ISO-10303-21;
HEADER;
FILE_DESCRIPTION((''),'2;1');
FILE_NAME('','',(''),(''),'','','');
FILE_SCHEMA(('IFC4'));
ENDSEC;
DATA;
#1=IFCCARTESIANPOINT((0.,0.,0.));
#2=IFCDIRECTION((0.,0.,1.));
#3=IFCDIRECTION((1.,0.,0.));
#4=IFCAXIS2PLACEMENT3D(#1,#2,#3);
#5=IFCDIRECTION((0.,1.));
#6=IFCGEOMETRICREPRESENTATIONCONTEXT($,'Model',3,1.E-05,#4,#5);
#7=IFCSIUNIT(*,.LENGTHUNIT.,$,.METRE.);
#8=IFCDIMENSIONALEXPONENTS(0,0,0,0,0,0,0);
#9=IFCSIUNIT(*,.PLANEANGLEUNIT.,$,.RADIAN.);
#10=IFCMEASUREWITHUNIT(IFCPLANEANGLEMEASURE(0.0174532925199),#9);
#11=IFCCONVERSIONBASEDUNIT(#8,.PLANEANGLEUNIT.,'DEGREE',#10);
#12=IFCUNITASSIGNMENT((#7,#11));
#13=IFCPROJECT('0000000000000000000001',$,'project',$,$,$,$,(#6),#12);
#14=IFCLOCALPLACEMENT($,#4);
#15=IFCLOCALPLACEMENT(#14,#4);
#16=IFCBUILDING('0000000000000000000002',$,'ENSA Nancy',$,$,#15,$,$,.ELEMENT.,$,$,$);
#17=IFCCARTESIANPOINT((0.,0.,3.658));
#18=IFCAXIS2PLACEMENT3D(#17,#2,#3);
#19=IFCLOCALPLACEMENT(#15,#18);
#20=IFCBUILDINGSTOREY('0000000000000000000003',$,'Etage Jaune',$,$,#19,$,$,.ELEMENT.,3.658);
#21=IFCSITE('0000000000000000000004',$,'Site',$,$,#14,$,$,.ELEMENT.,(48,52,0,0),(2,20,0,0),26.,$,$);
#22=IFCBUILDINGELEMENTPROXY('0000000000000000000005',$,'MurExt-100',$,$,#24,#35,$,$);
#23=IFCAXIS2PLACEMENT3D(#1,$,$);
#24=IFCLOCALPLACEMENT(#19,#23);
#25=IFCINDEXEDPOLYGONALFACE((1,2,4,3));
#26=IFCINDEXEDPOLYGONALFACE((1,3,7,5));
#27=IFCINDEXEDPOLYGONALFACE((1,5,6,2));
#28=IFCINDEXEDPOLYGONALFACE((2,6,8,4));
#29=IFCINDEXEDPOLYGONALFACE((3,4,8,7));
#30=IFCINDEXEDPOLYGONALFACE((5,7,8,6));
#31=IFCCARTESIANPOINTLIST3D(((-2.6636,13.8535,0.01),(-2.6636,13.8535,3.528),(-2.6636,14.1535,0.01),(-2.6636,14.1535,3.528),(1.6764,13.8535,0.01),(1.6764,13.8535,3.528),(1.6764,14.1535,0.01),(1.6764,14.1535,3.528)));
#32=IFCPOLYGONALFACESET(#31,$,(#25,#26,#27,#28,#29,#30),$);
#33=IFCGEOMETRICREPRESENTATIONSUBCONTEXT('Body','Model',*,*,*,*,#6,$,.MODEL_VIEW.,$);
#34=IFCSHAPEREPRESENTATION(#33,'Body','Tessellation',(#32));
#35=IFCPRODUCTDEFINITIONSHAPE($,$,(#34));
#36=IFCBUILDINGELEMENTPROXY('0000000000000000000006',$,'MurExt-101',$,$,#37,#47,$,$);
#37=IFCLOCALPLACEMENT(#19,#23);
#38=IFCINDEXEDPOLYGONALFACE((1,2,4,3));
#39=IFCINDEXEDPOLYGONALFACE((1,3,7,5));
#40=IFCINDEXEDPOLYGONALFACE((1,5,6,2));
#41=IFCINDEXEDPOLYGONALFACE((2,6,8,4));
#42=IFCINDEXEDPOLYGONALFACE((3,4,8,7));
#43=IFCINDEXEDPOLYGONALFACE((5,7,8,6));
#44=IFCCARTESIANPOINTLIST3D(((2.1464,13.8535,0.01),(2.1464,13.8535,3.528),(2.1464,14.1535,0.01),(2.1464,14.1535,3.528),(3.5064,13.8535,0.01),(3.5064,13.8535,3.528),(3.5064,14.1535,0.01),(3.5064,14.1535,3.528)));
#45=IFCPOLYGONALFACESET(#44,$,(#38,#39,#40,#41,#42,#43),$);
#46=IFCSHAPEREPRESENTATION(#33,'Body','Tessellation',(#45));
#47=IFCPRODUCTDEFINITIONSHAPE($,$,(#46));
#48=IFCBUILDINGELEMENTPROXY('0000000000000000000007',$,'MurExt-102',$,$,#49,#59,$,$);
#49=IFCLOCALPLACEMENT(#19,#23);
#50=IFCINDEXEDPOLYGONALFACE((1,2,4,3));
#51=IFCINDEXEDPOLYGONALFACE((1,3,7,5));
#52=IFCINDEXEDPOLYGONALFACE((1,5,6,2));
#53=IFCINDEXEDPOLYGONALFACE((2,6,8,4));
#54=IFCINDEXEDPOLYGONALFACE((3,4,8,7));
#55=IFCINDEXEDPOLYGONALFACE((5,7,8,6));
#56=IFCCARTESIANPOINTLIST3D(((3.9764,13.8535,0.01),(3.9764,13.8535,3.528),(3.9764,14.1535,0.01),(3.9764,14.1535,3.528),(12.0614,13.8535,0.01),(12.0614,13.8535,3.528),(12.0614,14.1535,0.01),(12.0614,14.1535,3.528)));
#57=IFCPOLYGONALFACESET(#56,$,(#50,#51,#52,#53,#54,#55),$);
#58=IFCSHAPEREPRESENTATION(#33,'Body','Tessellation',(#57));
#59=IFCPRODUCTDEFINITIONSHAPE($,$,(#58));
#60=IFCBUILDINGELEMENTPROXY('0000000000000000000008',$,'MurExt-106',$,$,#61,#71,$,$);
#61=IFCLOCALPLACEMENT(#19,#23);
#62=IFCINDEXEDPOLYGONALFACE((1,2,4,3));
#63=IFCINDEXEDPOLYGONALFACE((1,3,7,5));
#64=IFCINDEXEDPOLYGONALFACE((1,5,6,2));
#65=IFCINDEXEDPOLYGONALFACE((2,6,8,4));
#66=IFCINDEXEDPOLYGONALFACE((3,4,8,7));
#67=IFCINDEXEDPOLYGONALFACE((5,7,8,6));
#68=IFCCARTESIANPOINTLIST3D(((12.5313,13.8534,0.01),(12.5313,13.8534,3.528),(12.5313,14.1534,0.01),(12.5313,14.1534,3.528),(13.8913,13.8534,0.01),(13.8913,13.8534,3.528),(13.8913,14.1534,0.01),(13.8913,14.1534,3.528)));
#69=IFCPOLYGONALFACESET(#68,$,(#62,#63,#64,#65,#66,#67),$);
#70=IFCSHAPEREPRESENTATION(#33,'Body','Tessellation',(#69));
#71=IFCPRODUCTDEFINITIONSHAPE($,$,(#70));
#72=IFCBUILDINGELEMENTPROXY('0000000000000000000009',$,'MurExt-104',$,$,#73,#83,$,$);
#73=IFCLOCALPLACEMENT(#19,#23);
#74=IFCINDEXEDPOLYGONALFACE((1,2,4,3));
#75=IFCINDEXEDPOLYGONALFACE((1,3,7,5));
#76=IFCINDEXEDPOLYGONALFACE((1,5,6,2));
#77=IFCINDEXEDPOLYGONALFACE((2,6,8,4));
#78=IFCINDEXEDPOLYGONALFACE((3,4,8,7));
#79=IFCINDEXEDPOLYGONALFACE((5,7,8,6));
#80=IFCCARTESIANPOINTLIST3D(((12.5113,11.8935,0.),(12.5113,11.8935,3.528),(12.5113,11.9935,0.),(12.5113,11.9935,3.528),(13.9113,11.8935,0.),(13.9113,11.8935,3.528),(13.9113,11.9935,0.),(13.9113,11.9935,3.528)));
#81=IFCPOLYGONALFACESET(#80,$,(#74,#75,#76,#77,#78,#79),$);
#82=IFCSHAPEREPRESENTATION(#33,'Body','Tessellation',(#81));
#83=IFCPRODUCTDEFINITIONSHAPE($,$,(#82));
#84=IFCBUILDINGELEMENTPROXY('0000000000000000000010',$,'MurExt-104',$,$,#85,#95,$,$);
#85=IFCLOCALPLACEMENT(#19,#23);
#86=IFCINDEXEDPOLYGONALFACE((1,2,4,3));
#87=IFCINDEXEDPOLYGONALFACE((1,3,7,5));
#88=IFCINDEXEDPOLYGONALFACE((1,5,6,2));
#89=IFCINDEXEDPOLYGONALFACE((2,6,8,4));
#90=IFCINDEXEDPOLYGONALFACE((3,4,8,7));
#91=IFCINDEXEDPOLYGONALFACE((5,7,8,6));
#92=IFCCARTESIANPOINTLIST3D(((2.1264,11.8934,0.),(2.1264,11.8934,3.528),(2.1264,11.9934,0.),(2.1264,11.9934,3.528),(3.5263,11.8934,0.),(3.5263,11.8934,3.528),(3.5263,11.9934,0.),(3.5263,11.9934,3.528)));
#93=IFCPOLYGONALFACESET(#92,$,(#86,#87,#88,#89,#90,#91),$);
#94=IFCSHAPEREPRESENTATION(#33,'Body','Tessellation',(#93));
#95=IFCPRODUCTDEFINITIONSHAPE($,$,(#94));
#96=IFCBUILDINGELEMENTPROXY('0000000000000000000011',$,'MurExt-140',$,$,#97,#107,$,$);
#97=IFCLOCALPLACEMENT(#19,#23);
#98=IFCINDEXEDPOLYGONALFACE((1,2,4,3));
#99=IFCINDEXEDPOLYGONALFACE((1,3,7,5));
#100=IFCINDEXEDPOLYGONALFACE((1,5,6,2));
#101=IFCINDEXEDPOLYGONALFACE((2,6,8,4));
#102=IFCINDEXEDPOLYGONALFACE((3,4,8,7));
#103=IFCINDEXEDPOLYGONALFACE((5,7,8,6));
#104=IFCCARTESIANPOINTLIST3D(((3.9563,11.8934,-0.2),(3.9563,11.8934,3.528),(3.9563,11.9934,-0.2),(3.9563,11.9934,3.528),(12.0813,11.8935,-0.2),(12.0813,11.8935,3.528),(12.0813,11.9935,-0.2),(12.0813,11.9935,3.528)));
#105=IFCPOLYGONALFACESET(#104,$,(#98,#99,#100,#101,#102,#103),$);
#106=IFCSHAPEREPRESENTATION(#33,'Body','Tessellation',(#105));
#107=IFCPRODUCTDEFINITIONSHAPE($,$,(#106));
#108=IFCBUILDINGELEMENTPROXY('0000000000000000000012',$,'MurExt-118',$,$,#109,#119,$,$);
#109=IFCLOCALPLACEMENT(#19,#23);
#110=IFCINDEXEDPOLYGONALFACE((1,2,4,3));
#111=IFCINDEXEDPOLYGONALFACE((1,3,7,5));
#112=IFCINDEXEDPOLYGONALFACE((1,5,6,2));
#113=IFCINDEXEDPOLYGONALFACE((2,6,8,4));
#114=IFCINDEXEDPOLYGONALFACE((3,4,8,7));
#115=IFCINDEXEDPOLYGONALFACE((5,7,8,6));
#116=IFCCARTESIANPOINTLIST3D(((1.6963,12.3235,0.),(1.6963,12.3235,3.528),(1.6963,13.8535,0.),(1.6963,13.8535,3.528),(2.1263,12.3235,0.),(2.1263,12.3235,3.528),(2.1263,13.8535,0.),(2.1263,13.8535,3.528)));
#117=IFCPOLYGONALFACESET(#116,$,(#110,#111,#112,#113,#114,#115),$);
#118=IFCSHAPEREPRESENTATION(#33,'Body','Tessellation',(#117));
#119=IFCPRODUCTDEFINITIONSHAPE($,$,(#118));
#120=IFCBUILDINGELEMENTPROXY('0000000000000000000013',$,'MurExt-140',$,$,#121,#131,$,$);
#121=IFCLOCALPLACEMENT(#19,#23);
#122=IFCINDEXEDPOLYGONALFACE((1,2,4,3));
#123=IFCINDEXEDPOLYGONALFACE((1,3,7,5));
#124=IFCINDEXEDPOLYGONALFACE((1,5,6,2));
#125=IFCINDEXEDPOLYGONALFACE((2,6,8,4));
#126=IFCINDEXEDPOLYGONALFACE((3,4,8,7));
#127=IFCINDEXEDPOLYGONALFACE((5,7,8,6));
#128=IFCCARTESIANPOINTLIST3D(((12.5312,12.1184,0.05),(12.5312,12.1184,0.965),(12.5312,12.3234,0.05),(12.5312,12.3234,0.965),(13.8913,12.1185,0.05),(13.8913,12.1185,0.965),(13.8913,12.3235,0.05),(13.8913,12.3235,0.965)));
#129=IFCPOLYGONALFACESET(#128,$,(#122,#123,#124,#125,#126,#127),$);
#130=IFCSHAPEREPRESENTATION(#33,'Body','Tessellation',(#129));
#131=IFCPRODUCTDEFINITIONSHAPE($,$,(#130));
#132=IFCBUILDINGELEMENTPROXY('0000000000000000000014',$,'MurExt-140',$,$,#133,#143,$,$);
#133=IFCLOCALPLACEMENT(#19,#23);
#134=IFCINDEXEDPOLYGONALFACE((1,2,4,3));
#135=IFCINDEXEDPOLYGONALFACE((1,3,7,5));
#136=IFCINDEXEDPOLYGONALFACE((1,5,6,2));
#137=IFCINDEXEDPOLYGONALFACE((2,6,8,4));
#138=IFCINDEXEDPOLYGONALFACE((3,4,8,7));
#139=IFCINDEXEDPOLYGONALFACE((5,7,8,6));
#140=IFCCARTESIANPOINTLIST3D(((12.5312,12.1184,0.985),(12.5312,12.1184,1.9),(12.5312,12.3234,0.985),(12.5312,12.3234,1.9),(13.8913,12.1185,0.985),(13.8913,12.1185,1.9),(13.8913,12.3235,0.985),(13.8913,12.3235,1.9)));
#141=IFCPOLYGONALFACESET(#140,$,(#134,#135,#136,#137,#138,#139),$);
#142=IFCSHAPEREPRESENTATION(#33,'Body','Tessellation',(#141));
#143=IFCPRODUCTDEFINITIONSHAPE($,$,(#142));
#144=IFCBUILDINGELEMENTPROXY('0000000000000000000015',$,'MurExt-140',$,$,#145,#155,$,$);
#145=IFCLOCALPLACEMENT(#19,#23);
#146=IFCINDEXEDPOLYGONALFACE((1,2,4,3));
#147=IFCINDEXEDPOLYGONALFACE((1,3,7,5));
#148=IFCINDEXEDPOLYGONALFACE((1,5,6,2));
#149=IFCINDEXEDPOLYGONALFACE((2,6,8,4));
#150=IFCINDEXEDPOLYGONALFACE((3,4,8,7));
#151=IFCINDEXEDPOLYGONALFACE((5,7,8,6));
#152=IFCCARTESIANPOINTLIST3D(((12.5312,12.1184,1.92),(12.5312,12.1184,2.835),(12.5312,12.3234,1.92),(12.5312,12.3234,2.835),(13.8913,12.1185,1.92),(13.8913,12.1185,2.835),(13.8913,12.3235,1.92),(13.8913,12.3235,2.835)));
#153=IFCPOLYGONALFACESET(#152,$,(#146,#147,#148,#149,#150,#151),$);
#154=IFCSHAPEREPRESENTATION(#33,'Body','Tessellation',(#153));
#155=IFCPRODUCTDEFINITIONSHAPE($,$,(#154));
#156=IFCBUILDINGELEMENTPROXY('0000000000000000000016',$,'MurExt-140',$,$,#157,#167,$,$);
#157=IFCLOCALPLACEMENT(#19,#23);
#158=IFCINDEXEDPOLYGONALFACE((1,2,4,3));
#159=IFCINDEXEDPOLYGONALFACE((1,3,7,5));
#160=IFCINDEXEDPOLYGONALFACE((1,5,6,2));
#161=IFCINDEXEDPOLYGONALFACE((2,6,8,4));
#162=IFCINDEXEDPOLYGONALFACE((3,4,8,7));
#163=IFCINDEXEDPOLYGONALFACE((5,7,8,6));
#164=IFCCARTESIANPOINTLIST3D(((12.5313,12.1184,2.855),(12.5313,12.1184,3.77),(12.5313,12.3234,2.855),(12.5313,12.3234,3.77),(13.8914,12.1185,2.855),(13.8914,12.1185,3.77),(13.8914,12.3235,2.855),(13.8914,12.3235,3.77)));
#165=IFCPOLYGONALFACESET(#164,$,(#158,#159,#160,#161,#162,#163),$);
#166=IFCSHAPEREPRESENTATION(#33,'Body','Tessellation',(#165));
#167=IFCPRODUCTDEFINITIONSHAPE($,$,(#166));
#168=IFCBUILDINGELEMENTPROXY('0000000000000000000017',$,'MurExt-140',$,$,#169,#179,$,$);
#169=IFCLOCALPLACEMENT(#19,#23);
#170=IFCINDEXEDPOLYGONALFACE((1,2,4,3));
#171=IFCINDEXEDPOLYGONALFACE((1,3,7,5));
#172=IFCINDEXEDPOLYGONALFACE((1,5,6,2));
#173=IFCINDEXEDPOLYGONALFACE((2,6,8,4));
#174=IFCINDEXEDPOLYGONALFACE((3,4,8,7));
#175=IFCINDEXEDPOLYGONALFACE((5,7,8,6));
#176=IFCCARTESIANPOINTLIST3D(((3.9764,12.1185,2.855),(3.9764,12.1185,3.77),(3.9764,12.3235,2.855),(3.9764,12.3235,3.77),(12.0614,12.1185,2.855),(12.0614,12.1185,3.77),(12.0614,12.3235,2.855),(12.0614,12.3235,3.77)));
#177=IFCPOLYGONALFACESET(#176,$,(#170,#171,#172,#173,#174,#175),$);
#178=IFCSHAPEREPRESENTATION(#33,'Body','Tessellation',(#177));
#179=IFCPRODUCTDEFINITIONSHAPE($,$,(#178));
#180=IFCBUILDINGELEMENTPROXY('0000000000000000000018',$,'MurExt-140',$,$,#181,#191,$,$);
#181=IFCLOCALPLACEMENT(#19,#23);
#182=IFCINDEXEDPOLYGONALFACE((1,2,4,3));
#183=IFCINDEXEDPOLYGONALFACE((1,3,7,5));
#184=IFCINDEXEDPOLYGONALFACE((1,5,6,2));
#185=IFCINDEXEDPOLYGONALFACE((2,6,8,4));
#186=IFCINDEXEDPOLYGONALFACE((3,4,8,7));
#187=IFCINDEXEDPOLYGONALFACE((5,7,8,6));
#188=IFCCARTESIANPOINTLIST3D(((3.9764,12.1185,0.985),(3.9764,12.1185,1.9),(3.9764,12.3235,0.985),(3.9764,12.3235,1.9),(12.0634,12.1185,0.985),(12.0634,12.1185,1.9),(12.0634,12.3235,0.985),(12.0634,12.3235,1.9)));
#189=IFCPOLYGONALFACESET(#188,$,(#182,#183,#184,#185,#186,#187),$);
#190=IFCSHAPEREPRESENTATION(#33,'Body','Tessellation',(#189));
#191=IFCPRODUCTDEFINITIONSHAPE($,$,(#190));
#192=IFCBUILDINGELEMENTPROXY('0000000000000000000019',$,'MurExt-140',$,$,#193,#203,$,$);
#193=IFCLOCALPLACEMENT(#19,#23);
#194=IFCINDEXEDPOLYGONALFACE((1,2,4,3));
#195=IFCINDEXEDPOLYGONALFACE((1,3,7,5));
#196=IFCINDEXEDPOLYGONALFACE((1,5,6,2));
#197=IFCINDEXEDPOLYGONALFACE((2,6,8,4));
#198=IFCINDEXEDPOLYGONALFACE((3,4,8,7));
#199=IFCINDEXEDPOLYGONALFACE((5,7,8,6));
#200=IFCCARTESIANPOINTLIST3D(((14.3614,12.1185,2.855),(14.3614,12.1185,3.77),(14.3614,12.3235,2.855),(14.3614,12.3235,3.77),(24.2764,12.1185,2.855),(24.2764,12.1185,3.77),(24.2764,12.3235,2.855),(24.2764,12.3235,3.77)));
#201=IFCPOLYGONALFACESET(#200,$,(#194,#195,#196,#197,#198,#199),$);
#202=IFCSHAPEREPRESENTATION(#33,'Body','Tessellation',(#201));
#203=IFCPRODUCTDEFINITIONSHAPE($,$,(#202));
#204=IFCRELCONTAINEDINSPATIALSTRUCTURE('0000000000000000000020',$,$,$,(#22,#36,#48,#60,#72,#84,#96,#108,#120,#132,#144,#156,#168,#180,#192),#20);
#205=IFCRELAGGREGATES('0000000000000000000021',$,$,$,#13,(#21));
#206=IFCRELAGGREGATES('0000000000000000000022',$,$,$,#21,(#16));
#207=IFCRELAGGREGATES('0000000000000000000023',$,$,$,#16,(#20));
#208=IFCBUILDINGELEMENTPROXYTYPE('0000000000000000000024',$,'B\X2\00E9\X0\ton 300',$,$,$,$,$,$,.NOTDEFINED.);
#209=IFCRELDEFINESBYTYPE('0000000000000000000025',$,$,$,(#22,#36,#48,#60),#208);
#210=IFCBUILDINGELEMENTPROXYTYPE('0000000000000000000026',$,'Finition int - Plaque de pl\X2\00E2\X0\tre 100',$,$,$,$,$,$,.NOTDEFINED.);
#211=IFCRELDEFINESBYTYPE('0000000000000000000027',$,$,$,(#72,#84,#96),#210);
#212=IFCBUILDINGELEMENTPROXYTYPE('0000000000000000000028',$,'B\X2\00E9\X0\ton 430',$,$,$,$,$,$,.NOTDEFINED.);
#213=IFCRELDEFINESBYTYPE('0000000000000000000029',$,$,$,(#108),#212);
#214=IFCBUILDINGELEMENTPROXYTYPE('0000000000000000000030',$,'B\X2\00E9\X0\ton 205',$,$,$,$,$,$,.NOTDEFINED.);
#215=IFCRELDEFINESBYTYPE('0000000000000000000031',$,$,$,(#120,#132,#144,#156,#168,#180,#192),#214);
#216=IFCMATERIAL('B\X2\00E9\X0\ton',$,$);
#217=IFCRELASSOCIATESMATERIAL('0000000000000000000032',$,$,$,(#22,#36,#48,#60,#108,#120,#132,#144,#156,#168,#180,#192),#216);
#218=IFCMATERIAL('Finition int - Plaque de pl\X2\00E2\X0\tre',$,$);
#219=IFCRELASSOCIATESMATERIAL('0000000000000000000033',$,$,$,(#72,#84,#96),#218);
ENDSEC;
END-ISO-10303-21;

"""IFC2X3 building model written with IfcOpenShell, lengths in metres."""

from ifc_helpers import new_model, entity, si_unit, converted_unit, direction, frame, origin_with_axes, place, context, subcontext, project, spatial, polyline, outline, extrude, material, type_object, element, save


model = new_model("IFC2X3")

# Units and contexts
model_context = context("Model", 3, precision=1e-05, world=origin_with_axes(), true_north=direction((0.0, 1.0)))
body_context = subcontext(model_context, "Body", "Model", "MODEL_VIEW")
ifc_project = project(units=[si_unit("LENGTHUNIT", "METRE"), converted_unit("PLANEANGLEUNIT", "DEGREE", entity("IfcPlaneAngleMeasure", 0.0174532925199), si_unit("PLANEANGLEUNIT", "RADIAN"), dimensions=[0, 0, 0, 0, 0, 0, 0])], contexts=[model_context])

# Site, building, storey
site_placement = place(None, origin_with_axes())
site = spatial("IfcSite", under=ifc_project, at=site_placement, Name="Site", CompositionType="ELEMENT", RefLatitude=(48, 52, 0, 0), RefLongitude=(2, 20, 0, 0), RefElevation=26.0)
building_placement = place(site_placement, origin_with_axes())
building = spatial("IfcBuilding", under=site, at=building_placement, Name="ENSA Nancy", CompositionType="ELEMENT")
storey_placement = place(building_placement, frame((0.0, 0.0, 3.658), z_axis=(0.0, 0.0, 1.0), x_axis=(1.0, 0.0, 0.0)))
storey = spatial("IfcBuildingStorey", under=building, at=storey_placement, Name="Etage Jaune", CompositionType="ELEMENT", Elevation=3.658)

# Building element proxies
ifc_material_1 = material(Name="Béton")
building_element_proxy_type_1 = type_object("IfcBuildingElementProxyType", Name="Béton 300", PredefinedType="NOTDEFINED")
proxy_1_placement = place(storey_placement, frame((-2.6636, 13.8535, 0.01), z_axis=(0.0, 0.0, 1.0), x_axis=(1.0, 0.0, 0.0)))
element("IfcBuildingElementProxy", 1, at=proxy_1_placement, inside=storey, type_object=building_element_proxy_type_1, material=ifc_material_1, Name="MurExt-100", context=body_context, shape_type="SweptSolid", body=[
    extrude(outline(polyline([(0.0, 0.0), (4.34, 0.0), (4.34, 0.3), (0.0, 0.3), (0.0, 0.0)])), origin_with_axes(), (0.0, 0.0, 1.0), 3.518),
])
proxy_2_placement = place(storey_placement, frame((2.1464, 13.8535, 0.01), z_axis=(0.0, 0.0, 1.0), x_axis=(1.0, 0.0, 0.0)))
element("IfcBuildingElementProxy", 2, at=proxy_2_placement, inside=storey, type_object=building_element_proxy_type_1, material=ifc_material_1, Name="MurExt-101", context=body_context, shape_type="SweptSolid", body=[
    extrude(outline(polyline([(0.0, 0.0), (1.36, 0.0), (1.36, 0.3), (0.0, 0.3), (0.0, 0.0)])), origin_with_axes(), (0.0, 0.0, 1.0), 3.518),
])
proxy_3_placement = place(storey_placement, frame((3.9764, 13.8535, 0.01), z_axis=(0.0, 0.0, 1.0), x_axis=(1.0, 0.000001, 0.0)))
element("IfcBuildingElementProxy", 3, at=proxy_3_placement, inside=storey, type_object=building_element_proxy_type_1, material=ifc_material_1, Name="MurExt-102", context=body_context, shape_type="SweptSolid", body=[
    extrude(outline(polyline([(0.0, 0.0), (8.085, 0.0), (8.085, 0.3), (0.0, 0.3), (0.0, 0.0)])), origin_with_axes(), (0.0, 0.0, 1.0), 3.518),
])
proxy_4_placement = place(storey_placement, frame((12.5313, 13.8534, 0.01), z_axis=(0.0, 0.0, 1.0), x_axis=(1.0, 0.0, 0.0)))
element("IfcBuildingElementProxy", 4, at=proxy_4_placement, inside=storey, type_object=building_element_proxy_type_1, material=ifc_material_1, Name="MurExt-106", context=body_context, shape_type="SweptSolid", body=[
    extrude(outline(polyline([(0.0, 0.0), (1.36, 0.0), (1.36, 0.3), (0.0, 0.3), (0.0, 0.0)])), origin_with_axes(), (0.0, 0.0, 1.0), 3.518),
])
ifc_material_2 = material(Name="Finition int - Plaque de plâtre")
building_element_proxy_type_2 = type_object("IfcBuildingElementProxyType", Name="Finition int - Plaque de plâtre 100", PredefinedType="NOTDEFINED")
proxy_5_placement = place(storey_placement, frame((12.5113, 11.8935, 0.0), z_axis=(0.0, 0.0, 1.0), x_axis=(1.0, 0.0, 0.0)))
element("IfcBuildingElementProxy", 5, at=proxy_5_placement, inside=storey, type_object=building_element_proxy_type_2, material=ifc_material_2, Name="MurExt-104", context=body_context, shape_type="SweptSolid", body=[
    extrude(outline(polyline([(0.0, 0.0), (1.4, 0.0), (1.4, 0.1), (0.0, 0.1), (0.0, 0.0)])), origin_with_axes(), (0.0, 0.0, 1.0), 3.528),
])
proxy_6_placement = place(storey_placement, frame((2.1264, 11.8934, 0.0), z_axis=(0.0, 0.0, 1.0), x_axis=(1.0, -0.000001, 0.0)))
element("IfcBuildingElementProxy", 6, at=proxy_6_placement, inside=storey, type_object=building_element_proxy_type_2, material=ifc_material_2, Name="MurExt-104", context=body_context, shape_type="SweptSolid", body=[
    extrude(outline(polyline([(0.0, 0.0), (1.4, 0.0), (1.4, 0.1), (0.0, 0.1), (0.0, 0.0)])), origin_with_axes(), (0.0, 0.0, 1.0), 3.528),
])
proxy_7_placement = place(storey_placement, frame((3.9563, 11.8934, -0.2), z_axis=(0.0, 0.0, 1.0), x_axis=(1.0, 0.000006, 0.0)))
element("IfcBuildingElementProxy", 7, at=proxy_7_placement, inside=storey, type_object=building_element_proxy_type_2, material=ifc_material_2, Name="MurExt-140", context=body_context, shape_type="SweptSolid", body=[
    extrude(outline(polyline([(0.0, 0.0), (8.125, 0.0), (8.125, 0.1), (0.0, 0.1), (0.0, 0.0)])), origin_with_axes(), (0.0, 0.0, 1.0), 3.728),
])
building_element_proxy_type_3 = type_object("IfcBuildingElementProxyType", Name="Béton 430", PredefinedType="NOTDEFINED")
proxy_8_placement = place(storey_placement, frame((1.6963, 13.8535, 0.0), z_axis=(0.0, 0.0, 1.0), x_axis=(0.0, -1.0, 0.0)))
element("IfcBuildingElementProxy", 8, at=proxy_8_placement, inside=storey, type_object=building_element_proxy_type_3, material=ifc_material_1, Name="MurExt-118", context=body_context, shape_type="SweptSolid", body=[
    extrude(outline(polyline([(0.0, 0.0), (1.53, 0.0), (1.53, 0.43), (0.0, 0.43), (0.0, 0.0)])), origin_with_axes(), (0.0, 0.0, 1.0), 3.528),
])
building_element_proxy_type_4 = type_object("IfcBuildingElementProxyType", Name="Béton 205", PredefinedType="NOTDEFINED")
for number, where, z_axis, x_axis, name in (
    (9, (12.5312, 12.3234, 0.05), (0.0, 0.0, 1.0), (1.0, 0.000034, 0.0), "MurExt-140"),
    (10, (12.5312, 12.3234, 0.985), (0.0, 0.0, 1.0), (1.0, 0.000034, 0.0), "MurExt-140"),
    (11, (12.5312, 12.3234, 1.92), (0.0, 0.0, 1.0), (1.0, 0.000034, 0.0), "MurExt-140"),
    (12, (12.5313, 12.3234, 2.855), (0.0, 0.0, 1.0), (1.0, 0.000034, 0.0), "MurExt-140"),
):
    element("IfcBuildingElementProxy", number, at=place(storey_placement, frame(where, z_axis=z_axis, x_axis=x_axis)), inside=storey, type_object=building_element_proxy_type_4, material=ifc_material_1, Name=name, context=body_context, shape_type="SweptSolid", body=[
        extrude(outline(polyline([(0.0, -0.205), (1.3601, -0.205), (1.3601, 0.0), (0.0, 0.0), (0.0, -0.205)])), origin_with_axes(), (0.0, 0.0, 1.0), 0.915),
    ])
proxy_9_placement = place(storey_placement, frame((3.9764, 12.3235, 2.855), z_axis=(0.0, 0.0, 1.0), x_axis=(1.0, 0.0, 0.0)))
element("IfcBuildingElementProxy", 13, at=proxy_9_placement, inside=storey, type_object=building_element_proxy_type_4, material=ifc_material_1, Name="MurExt-140", context=body_context, shape_type="SweptSolid", body=[
    extrude(outline(polyline([(0.0, -0.205), (8.085, -0.205), (8.085, 0.0), (0.0, 0.0), (0.0, -0.205)])), origin_with_axes(), (0.0, 0.0, 1.0), 0.915),
])
proxy_10_placement = place(storey_placement, frame((3.9764, 12.3235, 0.985), z_axis=(0.0, 0.0, 1.0), x_axis=(1.0, 0.0, 0.0)))
element("IfcBuildingElementProxy", 14, at=proxy_10_placement, inside=storey, type_object=building_element_proxy_type_4, material=ifc_material_1, Name="MurExt-140", context=body_context, shape_type="SweptSolid", body=[
    extrude(outline(polyline([(0.0, -0.205), (8.087, -0.205), (8.087, 0.0), (0.0, 0.0), (0.0, -0.205)])), origin_with_axes(), (0.0, 0.0, 1.0), 0.915),
])
proxy_11_placement = place(storey_placement, frame((14.3614, 12.3235, 2.855), z_axis=(0.0, 0.0, 1.0), x_axis=(1.0, 0.0, 0.0)))
element("IfcBuildingElementProxy", 15, at=proxy_11_placement, inside=storey, type_object=building_element_proxy_type_4, material=ifc_material_1, Name="MurExt-140", context=body_context, shape_type="SweptSolid", body=[
    extrude(outline(polyline([(0.0, -0.205), (9.915, -0.205), (9.915, 0.0), (0.0, 0.0), (0.0, -0.205)])), origin_with_axes(), (0.0, 0.0, 1.0), 0.915),
])

save(model, "model.ifc")
